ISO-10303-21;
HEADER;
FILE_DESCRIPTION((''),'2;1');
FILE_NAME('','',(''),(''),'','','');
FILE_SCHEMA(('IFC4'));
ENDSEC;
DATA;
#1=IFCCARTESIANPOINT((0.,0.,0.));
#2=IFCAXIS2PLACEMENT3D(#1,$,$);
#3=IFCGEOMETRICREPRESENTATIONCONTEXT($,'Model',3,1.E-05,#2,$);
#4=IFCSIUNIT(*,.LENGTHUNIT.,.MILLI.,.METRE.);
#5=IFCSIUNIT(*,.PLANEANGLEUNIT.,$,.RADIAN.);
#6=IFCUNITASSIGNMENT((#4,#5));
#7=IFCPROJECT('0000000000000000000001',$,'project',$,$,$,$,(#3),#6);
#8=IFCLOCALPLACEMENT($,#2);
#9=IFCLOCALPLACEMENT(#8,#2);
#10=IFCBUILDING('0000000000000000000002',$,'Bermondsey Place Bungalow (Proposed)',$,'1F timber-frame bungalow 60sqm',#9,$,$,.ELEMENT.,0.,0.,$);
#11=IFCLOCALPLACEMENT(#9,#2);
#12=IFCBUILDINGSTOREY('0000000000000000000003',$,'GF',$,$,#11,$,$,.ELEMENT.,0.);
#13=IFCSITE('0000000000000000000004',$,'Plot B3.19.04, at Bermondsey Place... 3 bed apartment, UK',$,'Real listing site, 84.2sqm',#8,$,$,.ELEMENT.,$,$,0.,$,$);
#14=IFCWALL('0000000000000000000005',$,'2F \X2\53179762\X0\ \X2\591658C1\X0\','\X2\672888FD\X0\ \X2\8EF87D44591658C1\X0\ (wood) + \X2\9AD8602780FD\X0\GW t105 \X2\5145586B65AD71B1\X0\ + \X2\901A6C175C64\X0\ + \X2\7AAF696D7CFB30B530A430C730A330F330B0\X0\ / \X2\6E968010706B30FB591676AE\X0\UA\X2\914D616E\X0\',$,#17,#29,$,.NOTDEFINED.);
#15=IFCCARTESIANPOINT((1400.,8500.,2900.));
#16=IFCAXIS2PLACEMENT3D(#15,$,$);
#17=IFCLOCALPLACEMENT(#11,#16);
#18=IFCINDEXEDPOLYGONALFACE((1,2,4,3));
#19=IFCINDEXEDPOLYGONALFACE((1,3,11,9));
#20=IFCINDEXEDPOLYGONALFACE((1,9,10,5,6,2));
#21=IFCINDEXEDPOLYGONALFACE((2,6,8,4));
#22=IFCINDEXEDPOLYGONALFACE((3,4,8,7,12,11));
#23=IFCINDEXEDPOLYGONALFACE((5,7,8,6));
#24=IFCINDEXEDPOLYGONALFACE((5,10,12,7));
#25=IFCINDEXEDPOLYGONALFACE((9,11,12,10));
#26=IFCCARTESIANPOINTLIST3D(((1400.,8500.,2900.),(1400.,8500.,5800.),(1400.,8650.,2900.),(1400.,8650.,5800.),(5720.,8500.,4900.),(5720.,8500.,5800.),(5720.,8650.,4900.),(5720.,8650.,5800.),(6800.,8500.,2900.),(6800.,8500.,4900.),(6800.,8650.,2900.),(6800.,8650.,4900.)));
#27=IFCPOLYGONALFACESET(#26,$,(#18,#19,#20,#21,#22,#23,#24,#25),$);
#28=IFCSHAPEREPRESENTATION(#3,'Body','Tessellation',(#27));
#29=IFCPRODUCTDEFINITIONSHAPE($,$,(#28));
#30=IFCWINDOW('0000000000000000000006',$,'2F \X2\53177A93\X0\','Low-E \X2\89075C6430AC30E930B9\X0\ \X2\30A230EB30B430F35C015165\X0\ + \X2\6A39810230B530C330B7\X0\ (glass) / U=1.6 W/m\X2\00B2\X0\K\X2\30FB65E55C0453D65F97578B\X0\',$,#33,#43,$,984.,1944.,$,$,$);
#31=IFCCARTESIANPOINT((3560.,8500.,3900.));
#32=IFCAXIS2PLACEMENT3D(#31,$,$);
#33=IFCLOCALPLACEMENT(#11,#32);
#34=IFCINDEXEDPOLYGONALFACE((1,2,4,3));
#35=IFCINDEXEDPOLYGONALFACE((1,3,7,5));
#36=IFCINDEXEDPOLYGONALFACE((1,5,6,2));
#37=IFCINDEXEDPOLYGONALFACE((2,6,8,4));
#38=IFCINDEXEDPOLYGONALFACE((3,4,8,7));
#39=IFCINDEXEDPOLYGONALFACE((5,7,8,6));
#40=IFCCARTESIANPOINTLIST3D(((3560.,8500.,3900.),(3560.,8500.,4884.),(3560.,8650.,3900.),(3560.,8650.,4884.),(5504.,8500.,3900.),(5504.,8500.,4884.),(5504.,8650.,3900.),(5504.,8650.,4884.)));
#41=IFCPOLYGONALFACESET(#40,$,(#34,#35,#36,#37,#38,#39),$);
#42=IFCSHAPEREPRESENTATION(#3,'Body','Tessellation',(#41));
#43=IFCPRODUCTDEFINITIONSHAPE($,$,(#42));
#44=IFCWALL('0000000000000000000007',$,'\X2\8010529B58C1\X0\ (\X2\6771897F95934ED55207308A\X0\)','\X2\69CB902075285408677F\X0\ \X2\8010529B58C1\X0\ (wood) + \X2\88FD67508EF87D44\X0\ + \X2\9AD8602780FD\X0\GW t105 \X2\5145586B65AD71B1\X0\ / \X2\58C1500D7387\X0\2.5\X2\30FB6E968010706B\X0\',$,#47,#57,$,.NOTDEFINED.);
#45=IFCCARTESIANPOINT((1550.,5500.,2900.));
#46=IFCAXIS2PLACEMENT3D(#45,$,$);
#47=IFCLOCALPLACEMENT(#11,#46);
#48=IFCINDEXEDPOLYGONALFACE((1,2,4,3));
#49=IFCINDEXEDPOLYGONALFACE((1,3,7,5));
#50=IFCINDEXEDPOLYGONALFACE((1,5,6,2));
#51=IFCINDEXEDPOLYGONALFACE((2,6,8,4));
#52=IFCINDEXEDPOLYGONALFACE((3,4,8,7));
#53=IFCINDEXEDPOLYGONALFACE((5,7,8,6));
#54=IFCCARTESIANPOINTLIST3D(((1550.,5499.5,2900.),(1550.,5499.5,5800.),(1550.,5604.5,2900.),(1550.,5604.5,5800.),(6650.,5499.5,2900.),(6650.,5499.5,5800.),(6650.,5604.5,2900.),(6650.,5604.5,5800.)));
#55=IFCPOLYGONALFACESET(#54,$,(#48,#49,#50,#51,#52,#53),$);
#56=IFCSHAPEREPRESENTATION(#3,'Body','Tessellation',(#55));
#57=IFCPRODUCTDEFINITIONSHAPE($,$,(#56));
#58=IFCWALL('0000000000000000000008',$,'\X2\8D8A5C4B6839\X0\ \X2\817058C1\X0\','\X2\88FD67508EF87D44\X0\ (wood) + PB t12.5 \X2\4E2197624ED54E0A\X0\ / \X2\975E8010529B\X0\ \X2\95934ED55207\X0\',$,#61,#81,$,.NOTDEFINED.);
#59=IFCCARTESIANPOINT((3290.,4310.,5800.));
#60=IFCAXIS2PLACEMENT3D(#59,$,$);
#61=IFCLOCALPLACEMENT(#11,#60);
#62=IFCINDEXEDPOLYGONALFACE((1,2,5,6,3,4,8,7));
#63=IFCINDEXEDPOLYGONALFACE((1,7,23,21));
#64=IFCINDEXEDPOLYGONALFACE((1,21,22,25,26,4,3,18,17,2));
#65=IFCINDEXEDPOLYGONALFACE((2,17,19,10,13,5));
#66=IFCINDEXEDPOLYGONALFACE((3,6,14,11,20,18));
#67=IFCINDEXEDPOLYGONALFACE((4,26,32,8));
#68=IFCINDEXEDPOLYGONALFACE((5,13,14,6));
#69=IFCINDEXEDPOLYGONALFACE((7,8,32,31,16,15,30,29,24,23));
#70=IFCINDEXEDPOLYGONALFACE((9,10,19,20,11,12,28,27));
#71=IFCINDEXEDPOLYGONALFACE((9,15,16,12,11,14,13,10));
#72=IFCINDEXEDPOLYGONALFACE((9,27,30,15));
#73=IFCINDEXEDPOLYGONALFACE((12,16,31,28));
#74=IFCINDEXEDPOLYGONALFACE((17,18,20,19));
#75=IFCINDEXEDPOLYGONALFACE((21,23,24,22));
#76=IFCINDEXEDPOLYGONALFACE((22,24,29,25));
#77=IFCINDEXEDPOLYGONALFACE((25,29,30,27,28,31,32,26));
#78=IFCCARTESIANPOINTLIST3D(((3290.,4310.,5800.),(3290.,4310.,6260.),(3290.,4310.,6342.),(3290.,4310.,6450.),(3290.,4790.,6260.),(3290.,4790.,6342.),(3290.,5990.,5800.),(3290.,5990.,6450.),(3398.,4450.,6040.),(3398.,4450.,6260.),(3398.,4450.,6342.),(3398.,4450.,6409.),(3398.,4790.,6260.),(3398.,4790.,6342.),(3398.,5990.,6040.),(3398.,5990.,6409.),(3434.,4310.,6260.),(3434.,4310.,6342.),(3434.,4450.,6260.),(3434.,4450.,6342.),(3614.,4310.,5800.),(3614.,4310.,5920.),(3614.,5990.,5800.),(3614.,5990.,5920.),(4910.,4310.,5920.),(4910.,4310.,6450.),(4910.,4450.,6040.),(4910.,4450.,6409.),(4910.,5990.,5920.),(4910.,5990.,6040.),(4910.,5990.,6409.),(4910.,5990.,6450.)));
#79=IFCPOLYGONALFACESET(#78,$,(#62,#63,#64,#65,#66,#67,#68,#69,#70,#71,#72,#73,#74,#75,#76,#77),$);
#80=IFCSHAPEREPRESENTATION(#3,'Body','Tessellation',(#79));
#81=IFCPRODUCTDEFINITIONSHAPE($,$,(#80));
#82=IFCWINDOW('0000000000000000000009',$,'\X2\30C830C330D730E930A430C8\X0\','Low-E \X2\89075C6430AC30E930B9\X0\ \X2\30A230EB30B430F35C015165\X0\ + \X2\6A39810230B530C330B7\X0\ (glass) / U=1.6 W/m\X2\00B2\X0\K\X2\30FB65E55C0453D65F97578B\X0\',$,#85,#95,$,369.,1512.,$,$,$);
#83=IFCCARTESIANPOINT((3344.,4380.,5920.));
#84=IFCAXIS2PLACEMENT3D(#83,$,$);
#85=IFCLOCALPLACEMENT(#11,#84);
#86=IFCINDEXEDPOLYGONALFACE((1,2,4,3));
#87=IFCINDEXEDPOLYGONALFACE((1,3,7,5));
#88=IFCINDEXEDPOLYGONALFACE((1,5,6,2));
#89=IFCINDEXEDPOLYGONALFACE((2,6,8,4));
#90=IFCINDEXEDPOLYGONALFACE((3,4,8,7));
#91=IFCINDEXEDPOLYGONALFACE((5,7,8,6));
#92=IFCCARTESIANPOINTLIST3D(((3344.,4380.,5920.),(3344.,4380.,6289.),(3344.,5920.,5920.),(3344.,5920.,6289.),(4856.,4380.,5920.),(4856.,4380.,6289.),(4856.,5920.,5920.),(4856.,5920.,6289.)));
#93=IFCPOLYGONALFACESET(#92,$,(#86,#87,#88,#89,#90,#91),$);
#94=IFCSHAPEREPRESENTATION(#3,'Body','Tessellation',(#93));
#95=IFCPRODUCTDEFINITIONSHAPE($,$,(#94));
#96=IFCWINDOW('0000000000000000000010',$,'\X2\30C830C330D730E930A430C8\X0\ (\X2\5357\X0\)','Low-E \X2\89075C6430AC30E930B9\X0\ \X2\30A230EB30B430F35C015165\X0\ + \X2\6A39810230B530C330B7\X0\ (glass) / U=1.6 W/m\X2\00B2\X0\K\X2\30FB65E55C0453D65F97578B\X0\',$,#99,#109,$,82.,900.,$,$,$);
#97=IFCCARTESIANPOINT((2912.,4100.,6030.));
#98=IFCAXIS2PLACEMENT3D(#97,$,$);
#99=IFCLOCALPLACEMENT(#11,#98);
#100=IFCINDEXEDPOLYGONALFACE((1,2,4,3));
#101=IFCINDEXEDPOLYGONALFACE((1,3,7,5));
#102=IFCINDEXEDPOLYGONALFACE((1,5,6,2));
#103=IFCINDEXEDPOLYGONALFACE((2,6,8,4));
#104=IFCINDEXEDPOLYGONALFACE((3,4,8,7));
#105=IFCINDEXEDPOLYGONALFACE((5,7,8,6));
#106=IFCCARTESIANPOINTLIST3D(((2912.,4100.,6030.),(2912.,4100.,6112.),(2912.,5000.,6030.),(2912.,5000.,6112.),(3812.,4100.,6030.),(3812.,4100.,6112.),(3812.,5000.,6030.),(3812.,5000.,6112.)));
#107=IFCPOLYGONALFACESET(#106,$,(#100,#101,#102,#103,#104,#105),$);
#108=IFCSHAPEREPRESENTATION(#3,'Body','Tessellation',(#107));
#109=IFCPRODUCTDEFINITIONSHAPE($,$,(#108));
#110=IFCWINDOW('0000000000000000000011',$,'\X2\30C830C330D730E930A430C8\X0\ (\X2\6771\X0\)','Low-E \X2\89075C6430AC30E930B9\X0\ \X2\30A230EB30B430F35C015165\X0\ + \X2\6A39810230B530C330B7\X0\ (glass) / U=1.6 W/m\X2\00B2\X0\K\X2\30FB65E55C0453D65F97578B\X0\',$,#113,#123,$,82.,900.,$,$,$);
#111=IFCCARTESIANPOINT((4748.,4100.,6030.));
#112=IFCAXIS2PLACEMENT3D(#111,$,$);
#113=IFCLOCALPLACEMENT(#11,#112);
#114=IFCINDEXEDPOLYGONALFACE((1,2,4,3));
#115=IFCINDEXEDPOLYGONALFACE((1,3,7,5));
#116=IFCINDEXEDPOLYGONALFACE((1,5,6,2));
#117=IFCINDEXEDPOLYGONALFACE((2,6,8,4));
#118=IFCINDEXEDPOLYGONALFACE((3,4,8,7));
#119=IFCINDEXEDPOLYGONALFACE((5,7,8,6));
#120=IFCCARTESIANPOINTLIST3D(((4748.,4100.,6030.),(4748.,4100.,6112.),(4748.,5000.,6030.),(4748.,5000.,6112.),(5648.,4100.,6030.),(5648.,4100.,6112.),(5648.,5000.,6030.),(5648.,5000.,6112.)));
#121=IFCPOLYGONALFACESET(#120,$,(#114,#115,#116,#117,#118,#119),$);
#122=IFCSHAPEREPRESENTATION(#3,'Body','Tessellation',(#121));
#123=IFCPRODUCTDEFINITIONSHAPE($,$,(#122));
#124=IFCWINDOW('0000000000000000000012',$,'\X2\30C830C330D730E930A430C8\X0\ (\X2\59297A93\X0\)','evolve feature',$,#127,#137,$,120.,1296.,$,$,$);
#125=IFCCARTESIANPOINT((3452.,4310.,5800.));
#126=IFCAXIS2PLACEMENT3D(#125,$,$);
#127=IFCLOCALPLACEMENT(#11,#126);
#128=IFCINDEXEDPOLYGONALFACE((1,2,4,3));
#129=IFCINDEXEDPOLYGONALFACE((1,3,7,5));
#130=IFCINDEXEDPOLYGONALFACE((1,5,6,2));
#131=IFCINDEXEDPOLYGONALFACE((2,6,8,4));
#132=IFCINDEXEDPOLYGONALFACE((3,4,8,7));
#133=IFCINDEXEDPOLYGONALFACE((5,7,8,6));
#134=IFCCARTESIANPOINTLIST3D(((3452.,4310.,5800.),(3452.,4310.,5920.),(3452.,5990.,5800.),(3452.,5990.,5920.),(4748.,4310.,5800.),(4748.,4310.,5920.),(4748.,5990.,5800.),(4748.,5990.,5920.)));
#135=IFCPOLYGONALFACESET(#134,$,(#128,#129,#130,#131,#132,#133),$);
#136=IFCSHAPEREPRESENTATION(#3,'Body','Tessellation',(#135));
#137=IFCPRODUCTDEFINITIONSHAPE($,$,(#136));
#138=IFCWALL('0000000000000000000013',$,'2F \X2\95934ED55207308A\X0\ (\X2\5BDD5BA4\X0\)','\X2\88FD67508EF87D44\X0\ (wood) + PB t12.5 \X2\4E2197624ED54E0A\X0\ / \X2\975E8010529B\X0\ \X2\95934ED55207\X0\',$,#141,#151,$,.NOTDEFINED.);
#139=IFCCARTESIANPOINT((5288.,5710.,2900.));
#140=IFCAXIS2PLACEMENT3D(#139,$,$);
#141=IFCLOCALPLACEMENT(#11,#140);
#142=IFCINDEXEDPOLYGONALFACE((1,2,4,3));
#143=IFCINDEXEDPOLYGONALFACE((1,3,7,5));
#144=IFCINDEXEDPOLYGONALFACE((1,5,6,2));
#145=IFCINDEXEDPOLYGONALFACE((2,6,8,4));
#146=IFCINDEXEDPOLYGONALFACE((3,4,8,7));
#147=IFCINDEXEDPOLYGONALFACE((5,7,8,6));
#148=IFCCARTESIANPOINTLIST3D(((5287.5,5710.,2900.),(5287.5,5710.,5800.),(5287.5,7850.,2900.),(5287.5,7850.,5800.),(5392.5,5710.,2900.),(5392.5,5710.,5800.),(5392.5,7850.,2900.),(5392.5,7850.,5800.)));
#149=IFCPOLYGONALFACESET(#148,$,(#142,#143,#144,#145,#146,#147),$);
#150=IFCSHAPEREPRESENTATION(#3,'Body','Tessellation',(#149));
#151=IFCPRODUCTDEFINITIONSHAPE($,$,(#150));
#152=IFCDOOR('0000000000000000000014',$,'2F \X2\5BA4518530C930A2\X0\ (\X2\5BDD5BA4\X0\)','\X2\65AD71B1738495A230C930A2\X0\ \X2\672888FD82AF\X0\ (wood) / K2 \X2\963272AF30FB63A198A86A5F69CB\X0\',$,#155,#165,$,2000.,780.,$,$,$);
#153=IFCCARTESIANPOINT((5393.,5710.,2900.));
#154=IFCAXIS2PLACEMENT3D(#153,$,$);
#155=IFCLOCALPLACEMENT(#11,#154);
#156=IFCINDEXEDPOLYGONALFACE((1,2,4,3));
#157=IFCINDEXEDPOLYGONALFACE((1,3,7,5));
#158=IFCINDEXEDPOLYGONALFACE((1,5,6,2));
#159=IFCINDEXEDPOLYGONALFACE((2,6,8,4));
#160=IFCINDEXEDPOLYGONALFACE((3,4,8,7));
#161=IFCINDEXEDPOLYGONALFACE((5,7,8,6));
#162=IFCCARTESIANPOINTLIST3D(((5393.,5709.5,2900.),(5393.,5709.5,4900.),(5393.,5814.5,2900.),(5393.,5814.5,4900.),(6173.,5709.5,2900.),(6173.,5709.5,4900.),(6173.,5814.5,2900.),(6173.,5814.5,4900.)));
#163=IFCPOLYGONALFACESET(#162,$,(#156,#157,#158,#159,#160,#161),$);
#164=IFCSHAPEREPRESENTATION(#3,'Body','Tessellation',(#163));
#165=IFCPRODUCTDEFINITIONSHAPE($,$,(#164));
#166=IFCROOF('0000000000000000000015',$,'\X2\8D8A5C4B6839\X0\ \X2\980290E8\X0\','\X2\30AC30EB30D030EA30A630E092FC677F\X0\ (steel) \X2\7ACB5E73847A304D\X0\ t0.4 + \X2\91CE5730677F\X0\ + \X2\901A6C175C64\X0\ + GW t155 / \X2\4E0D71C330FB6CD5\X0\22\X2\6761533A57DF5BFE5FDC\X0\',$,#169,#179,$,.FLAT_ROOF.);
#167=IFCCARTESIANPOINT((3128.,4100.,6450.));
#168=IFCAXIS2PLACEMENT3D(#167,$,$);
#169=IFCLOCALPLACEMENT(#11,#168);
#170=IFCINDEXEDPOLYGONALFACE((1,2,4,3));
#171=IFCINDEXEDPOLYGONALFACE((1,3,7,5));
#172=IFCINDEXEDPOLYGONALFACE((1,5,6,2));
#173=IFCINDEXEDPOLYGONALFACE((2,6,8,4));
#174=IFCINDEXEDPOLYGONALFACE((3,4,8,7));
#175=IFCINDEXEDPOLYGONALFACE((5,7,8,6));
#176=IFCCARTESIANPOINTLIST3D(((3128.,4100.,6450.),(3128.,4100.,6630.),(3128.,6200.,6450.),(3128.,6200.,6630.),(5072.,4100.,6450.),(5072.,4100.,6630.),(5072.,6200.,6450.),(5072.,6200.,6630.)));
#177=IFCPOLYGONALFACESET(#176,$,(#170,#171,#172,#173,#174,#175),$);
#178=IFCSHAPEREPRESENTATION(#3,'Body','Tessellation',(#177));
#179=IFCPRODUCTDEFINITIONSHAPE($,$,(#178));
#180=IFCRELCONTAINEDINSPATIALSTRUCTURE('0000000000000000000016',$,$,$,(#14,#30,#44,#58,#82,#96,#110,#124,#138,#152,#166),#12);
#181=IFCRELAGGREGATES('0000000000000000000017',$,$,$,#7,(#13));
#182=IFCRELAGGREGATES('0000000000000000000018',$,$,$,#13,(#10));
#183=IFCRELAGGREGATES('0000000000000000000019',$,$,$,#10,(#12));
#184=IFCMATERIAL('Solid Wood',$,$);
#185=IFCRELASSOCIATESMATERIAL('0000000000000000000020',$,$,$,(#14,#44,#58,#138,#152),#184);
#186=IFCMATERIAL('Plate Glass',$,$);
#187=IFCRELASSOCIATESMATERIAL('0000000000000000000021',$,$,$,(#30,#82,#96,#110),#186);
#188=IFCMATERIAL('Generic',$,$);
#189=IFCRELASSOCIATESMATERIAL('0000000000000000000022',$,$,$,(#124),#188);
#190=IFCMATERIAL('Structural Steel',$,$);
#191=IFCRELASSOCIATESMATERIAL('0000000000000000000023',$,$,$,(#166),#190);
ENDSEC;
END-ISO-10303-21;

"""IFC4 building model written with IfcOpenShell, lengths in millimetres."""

from ifc_helpers import new_model, si_unit, frame, frame_2d, origin, place, context, project, spatial, rectangle, extrude, material, element, fill, save


model = new_model("IFC4")

# Units and contexts
model_context = context("Model", 3, precision=1e-05, world=origin())
ifc_project = project(units=[si_unit("LENGTHUNIT", "METRE", prefix="MILLI"), si_unit("PLANEANGLEUNIT", "RADIAN")], contexts=[model_context])

# Site, building, storey
site_placement = place(None, origin())
site = spatial("IfcSite", under=ifc_project, at=site_placement, Name="Plot B3.19.04, at Bermondsey Place... 3 bed apartment, UK", ObjectType="Real listing site, 84.2sqm", CompositionType="ELEMENT", RefElevation=0.0)
building_placement = place(site_placement, origin())
building = spatial("IfcBuilding", under=site, at=building_placement, Name="Bermondsey Place Bungalow (Proposed)", ObjectType="1F timber-frame bungalow 60sqm", CompositionType="ELEMENT", ElevationOfRefHeight=0.0, ElevationOfTerrain=0.0)
storey_placement = place(building_placement, origin())
storey = spatial("IfcBuildingStorey", under=building, at=storey_placement, Name="GF", CompositionType="ELEMENT", Elevation=0.0)

# Wall, opening, window
ifc_material_1 = material(Name="Solid Wood")
wall_1_placement = place(storey_placement, frame((1400.0, 8500.0, 2900.0)))
wall_1 = element("IfcWall", 1, at=wall_1_placement, inside=storey, material=ifc_material_1, Name="2F 北面 外壁", Description="木製 軸組外壁 (wood) + 高性能GW t105 充填断熱 + 通気層 + 窯業系サイディング / 準耐火・外皮UA配慮", PredefinedType="NOTDEFINED", context=model_context, shape_type="SweptSolid", body=[
    extrude(rectangle(XDim=5400.0, YDim=150.0, at=frame_2d((2700.0, 75.0))), frame((1400.0, 8500.0, 2900.0)), (0.0, 0.0, 1.0), 2900.0),
])
opening_1_placement = place(storey_placement, frame((3560.0, 8500.0, 3900.0)))
opening_1 = element("IfcOpeningElement", 2, at=opening_1_placement, cuts=wall_1, PredefinedType="NOTDEFINED", context=model_context, shape_type="SweptSolid", body=[
    extrude(rectangle(XDim=1944.0, YDim=150.0, at=frame_2d((972.0, 75.0))), frame((3560.0, 8500.0, 3900.0)), (0.0, 0.0, 1.0), 984.0),
])
ifc_material_2 = material(Name="Plate Glass")
window_1_placement = place(storey_placement, frame((3560.0, 8500.0, 3900.0)))
window_1 = element("IfcWindow", 3, at=window_1_placement, inside=storey, material=ifc_material_2, Name="2F 北窓", Description="Low-E 複層ガラス アルゴン封入 + 樹脂サッシ (glass) / U=1.6 W/m²K・日射取得型", OverallHeight=984.0, OverallWidth=1944.0, context=model_context, shape_type="SweptSolid", body=[
    extrude(rectangle(XDim=1944.0, YDim=150.0, at=frame_2d((972.0, 75.0))), frame((3560.0, 8500.0, 3900.0)), (0.0, 0.0, 1.0), 984.0),
])
fill(opening_1, window_1)

# Wall
wall_2_placement = place(storey_placement, frame((1550.0, 5500.0, 2900.0)))
element("IfcWall", 4, at=wall_2_placement, inside=storey, material=ifc_material_1, Name="耐力壁 (東西間仕切り)", Description="構造用合板 耐力壁 (wood) + 製材軸組 + 高性能GW t105 充填断熱 / 壁倍率2.5・準耐火", PredefinedType="NOTDEFINED", context=model_context, shape_type="SweptSolid", body=[
    extrude(rectangle(XDim=5100.0, YDim=105.0, at=frame_2d((2550.0, 52.0))), frame((1550.0, 5500.0, 2900.0)), (0.0, 0.0, 1.0), 2900.0),
])

# Wall, openings, windows
wall_3_placement = place(storey_placement, frame((3290.0, 4310.0, 5800.0)))
wall_3 = element("IfcWall", 5, at=wall_3_placement, inside=storey, material=ifc_material_1, Name="越屋根 腰壁", Description="製材軸組 (wood) + PB t12.5 両面仕上 / 非耐力 間仕切", PredefinedType="NOTDEFINED", context=model_context, shape_type="SweptSolid", body=[
    extrude(rectangle(XDim=1620.0, YDim=1680.0, at=frame_2d((810.0, 840.0))), frame((3290.0, 4310.0, 5800.0)), (0.0, 0.0, 1.0), 650.0),
])
opening_2_placement = place(storey_placement, frame((3344.0, 4380.0, 5920.0)))
opening_2 = element("IfcOpeningElement", 6, at=opening_2_placement, cuts=wall_3, PredefinedType="NOTDEFINED", context=model_context, shape_type="SweptSolid", body=[
    extrude(rectangle(XDim=1512.0, YDim=1540.0, at=frame_2d((756.0, 770.0))), frame((3344.0, 4380.0, 5920.0)), (0.0, 0.0, 1.0), 369.0),
])
opening_3_placement = place(storey_placement, frame((2912.0, 4100.0, 6030.0)))
opening_3 = element("IfcOpeningElement", 7, at=opening_3_placement, cuts=wall_3, PredefinedType="NOTDEFINED", context=model_context, shape_type="SweptSolid", body=[
    extrude(rectangle(XDim=900.0, YDim=900.0, at=frame_2d((450.0, 450.0))), frame((2912.0, 4100.0, 6030.0)), (0.0, 0.0, 1.0), 82.0),
])
opening_4_placement = place(storey_placement, frame((4748.0, 4100.0, 6030.0)))
opening_4 = element("IfcOpeningElement", 8, at=opening_4_placement, cuts=wall_3, PredefinedType="NOTDEFINED", context=model_context, shape_type="SweptSolid", body=[
    extrude(rectangle(XDim=900.0, YDim=900.0, at=frame_2d((450.0, 450.0))), frame((4748.0, 4100.0, 6030.0)), (0.0, 0.0, 1.0), 82.0),
])
opening_5_placement = place(storey_placement, frame((3452.0, 4310.0, 5800.0)))
opening_5 = element("IfcOpeningElement", 9, at=opening_5_placement, cuts=wall_3, PredefinedType="NOTDEFINED", context=model_context, shape_type="SweptSolid", body=[
    extrude(rectangle(XDim=1296.0, YDim=1680.0, at=frame_2d((648.0, 840.0))), frame((3452.0, 4310.0, 5800.0)), (0.0, 0.0, 1.0), 120.0),
])
window_2_placement = place(storey_placement, frame((3344.0, 4380.0, 5920.0)))
window_2 = element("IfcWindow", 10, at=window_2_placement, inside=storey, material=ifc_material_2, Name="トップライト", Description="Low-E 複層ガラス アルゴン封入 + 樹脂サッシ (glass) / U=1.6 W/m²K・日射取得型", OverallHeight=369.0, OverallWidth=1512.0, context=model_context, shape_type="SweptSolid", body=[
    extrude(rectangle(XDim=1512.0, YDim=1540.0, at=frame_2d((756.0, 770.0))), frame((3344.0, 4380.0, 5920.0)), (0.0, 0.0, 1.0), 369.0),
])
fill(opening_2, window_2)
window_3_placement = place(storey_placement, frame((2912.0, 4100.0, 6030.0)))
window_3 = element("IfcWindow", 11, at=window_3_placement, inside=storey, material=ifc_material_2, Name="トップライト (南)", Description="Low-E 複層ガラス アルゴン封入 + 樹脂サッシ (glass) / U=1.6 W/m²K・日射取得型", OverallHeight=82.0, OverallWidth=900.0, context=model_context, shape_type="SweptSolid", body=[
    extrude(rectangle(XDim=900.0, YDim=900.0, at=frame_2d((450.0, 450.0))), frame((2912.0, 4100.0, 6030.0)), (0.0, 0.0, 1.0), 82.0),
])
fill(opening_3, window_3)
window_4_placement = place(storey_placement, frame((4748.0, 4100.0, 6030.0)))
window_4 = element("IfcWindow", 12, at=window_4_placement, inside=storey, material=ifc_material_2, Name="トップライト (東)", Description="Low-E 複層ガラス アルゴン封入 + 樹脂サッシ (glass) / U=1.6 W/m²K・日射取得型", OverallHeight=82.0, OverallWidth=900.0, context=model_context, shape_type="SweptSolid", body=[
    extrude(rectangle(XDim=900.0, YDim=900.0, at=frame_2d((450.0, 450.0))), frame((4748.0, 4100.0, 6030.0)), (0.0, 0.0, 1.0), 82.0),
])
fill(opening_4, window_4)
ifc_material_3 = material(Name="Generic")
window_5_placement = place(storey_placement, frame((3452.0, 4310.0, 5800.0)))
window_5 = element("IfcWindow", 13, at=window_5_placement, inside=storey, material=ifc_material_3, Name="トップライト (天窓)", Description="evolve feature", OverallHeight=120.0, OverallWidth=1296.0, context=model_context, shape_type="SweptSolid", body=[
    extrude(rectangle(XDim=1296.0, YDim=1680.0, at=frame_2d((648.0, 840.0))), frame((3452.0, 4310.0, 5800.0)), (0.0, 0.0, 1.0), 120.0),
])
fill(opening_5, window_5)

# Wall
wall_4_placement = place(storey_placement, frame((5288.0, 5710.0, 2900.0)))
element("IfcWall", 14, at=wall_4_placement, inside=storey, material=ifc_material_1, Name="2F 間仕切り (寝室)", Description="製材軸組 (wood) + PB t12.5 両面仕上 / 非耐力 間仕切", PredefinedType="NOTDEFINED", context=model_context, shape_type="SweptSolid", body=[
    extrude(rectangle(XDim=105.0, YDim=2140.0, at=frame_2d((52.0, 1070.0))), frame((5288.0, 5710.0, 2900.0)), (0.0, 0.0, 1.0), 2900.0),
])

# Door
door_placement = place(storey_placement, frame((5393.0, 5710.0, 2900.0)))
element("IfcDoor", 15, at=door_placement, inside=storey, material=ifc_material_1, Name="2F 室内ドア (寝室)", Description="断熱玄関ドア 木製芯 (wood) / K2 防犯・採風機構", OverallHeight=2000.0, OverallWidth=780.0, context=model_context, shape_type="SweptSolid", body=[
    extrude(rectangle(XDim=780.0, YDim=105.0, at=frame_2d((390.0, 52.0))), frame((5393.0, 5710.0, 2900.0)), (0.0, 0.0, 1.0), 2000.0),
])

# Roof
ifc_material_4 = material(Name="Structural Steel")
roof_placement = place(storey_placement, frame((3128.0, 4100.0, 6450.0)))
element("IfcRoof", 16, at=roof_placement, inside=storey, material=ifc_material_4, Name="越屋根 頂部", Description="ガルバリウム鋼板 (steel) 立平葺き t0.4 + 野地板 + 通気層 + GW t155 / 不燃・法22条区域対応", PredefinedType="FLAT_ROOF", context=model_context, shape_type="SweptSolid", body=[
    extrude(rectangle(XDim=1944.0, YDim=2100.0, at=frame_2d((972.0, 1050.0))), frame((3128.0, 4100.0, 6450.0)), (0.0, 0.0, 1.0), 180.0),
])

save(model, "model.ifc")
